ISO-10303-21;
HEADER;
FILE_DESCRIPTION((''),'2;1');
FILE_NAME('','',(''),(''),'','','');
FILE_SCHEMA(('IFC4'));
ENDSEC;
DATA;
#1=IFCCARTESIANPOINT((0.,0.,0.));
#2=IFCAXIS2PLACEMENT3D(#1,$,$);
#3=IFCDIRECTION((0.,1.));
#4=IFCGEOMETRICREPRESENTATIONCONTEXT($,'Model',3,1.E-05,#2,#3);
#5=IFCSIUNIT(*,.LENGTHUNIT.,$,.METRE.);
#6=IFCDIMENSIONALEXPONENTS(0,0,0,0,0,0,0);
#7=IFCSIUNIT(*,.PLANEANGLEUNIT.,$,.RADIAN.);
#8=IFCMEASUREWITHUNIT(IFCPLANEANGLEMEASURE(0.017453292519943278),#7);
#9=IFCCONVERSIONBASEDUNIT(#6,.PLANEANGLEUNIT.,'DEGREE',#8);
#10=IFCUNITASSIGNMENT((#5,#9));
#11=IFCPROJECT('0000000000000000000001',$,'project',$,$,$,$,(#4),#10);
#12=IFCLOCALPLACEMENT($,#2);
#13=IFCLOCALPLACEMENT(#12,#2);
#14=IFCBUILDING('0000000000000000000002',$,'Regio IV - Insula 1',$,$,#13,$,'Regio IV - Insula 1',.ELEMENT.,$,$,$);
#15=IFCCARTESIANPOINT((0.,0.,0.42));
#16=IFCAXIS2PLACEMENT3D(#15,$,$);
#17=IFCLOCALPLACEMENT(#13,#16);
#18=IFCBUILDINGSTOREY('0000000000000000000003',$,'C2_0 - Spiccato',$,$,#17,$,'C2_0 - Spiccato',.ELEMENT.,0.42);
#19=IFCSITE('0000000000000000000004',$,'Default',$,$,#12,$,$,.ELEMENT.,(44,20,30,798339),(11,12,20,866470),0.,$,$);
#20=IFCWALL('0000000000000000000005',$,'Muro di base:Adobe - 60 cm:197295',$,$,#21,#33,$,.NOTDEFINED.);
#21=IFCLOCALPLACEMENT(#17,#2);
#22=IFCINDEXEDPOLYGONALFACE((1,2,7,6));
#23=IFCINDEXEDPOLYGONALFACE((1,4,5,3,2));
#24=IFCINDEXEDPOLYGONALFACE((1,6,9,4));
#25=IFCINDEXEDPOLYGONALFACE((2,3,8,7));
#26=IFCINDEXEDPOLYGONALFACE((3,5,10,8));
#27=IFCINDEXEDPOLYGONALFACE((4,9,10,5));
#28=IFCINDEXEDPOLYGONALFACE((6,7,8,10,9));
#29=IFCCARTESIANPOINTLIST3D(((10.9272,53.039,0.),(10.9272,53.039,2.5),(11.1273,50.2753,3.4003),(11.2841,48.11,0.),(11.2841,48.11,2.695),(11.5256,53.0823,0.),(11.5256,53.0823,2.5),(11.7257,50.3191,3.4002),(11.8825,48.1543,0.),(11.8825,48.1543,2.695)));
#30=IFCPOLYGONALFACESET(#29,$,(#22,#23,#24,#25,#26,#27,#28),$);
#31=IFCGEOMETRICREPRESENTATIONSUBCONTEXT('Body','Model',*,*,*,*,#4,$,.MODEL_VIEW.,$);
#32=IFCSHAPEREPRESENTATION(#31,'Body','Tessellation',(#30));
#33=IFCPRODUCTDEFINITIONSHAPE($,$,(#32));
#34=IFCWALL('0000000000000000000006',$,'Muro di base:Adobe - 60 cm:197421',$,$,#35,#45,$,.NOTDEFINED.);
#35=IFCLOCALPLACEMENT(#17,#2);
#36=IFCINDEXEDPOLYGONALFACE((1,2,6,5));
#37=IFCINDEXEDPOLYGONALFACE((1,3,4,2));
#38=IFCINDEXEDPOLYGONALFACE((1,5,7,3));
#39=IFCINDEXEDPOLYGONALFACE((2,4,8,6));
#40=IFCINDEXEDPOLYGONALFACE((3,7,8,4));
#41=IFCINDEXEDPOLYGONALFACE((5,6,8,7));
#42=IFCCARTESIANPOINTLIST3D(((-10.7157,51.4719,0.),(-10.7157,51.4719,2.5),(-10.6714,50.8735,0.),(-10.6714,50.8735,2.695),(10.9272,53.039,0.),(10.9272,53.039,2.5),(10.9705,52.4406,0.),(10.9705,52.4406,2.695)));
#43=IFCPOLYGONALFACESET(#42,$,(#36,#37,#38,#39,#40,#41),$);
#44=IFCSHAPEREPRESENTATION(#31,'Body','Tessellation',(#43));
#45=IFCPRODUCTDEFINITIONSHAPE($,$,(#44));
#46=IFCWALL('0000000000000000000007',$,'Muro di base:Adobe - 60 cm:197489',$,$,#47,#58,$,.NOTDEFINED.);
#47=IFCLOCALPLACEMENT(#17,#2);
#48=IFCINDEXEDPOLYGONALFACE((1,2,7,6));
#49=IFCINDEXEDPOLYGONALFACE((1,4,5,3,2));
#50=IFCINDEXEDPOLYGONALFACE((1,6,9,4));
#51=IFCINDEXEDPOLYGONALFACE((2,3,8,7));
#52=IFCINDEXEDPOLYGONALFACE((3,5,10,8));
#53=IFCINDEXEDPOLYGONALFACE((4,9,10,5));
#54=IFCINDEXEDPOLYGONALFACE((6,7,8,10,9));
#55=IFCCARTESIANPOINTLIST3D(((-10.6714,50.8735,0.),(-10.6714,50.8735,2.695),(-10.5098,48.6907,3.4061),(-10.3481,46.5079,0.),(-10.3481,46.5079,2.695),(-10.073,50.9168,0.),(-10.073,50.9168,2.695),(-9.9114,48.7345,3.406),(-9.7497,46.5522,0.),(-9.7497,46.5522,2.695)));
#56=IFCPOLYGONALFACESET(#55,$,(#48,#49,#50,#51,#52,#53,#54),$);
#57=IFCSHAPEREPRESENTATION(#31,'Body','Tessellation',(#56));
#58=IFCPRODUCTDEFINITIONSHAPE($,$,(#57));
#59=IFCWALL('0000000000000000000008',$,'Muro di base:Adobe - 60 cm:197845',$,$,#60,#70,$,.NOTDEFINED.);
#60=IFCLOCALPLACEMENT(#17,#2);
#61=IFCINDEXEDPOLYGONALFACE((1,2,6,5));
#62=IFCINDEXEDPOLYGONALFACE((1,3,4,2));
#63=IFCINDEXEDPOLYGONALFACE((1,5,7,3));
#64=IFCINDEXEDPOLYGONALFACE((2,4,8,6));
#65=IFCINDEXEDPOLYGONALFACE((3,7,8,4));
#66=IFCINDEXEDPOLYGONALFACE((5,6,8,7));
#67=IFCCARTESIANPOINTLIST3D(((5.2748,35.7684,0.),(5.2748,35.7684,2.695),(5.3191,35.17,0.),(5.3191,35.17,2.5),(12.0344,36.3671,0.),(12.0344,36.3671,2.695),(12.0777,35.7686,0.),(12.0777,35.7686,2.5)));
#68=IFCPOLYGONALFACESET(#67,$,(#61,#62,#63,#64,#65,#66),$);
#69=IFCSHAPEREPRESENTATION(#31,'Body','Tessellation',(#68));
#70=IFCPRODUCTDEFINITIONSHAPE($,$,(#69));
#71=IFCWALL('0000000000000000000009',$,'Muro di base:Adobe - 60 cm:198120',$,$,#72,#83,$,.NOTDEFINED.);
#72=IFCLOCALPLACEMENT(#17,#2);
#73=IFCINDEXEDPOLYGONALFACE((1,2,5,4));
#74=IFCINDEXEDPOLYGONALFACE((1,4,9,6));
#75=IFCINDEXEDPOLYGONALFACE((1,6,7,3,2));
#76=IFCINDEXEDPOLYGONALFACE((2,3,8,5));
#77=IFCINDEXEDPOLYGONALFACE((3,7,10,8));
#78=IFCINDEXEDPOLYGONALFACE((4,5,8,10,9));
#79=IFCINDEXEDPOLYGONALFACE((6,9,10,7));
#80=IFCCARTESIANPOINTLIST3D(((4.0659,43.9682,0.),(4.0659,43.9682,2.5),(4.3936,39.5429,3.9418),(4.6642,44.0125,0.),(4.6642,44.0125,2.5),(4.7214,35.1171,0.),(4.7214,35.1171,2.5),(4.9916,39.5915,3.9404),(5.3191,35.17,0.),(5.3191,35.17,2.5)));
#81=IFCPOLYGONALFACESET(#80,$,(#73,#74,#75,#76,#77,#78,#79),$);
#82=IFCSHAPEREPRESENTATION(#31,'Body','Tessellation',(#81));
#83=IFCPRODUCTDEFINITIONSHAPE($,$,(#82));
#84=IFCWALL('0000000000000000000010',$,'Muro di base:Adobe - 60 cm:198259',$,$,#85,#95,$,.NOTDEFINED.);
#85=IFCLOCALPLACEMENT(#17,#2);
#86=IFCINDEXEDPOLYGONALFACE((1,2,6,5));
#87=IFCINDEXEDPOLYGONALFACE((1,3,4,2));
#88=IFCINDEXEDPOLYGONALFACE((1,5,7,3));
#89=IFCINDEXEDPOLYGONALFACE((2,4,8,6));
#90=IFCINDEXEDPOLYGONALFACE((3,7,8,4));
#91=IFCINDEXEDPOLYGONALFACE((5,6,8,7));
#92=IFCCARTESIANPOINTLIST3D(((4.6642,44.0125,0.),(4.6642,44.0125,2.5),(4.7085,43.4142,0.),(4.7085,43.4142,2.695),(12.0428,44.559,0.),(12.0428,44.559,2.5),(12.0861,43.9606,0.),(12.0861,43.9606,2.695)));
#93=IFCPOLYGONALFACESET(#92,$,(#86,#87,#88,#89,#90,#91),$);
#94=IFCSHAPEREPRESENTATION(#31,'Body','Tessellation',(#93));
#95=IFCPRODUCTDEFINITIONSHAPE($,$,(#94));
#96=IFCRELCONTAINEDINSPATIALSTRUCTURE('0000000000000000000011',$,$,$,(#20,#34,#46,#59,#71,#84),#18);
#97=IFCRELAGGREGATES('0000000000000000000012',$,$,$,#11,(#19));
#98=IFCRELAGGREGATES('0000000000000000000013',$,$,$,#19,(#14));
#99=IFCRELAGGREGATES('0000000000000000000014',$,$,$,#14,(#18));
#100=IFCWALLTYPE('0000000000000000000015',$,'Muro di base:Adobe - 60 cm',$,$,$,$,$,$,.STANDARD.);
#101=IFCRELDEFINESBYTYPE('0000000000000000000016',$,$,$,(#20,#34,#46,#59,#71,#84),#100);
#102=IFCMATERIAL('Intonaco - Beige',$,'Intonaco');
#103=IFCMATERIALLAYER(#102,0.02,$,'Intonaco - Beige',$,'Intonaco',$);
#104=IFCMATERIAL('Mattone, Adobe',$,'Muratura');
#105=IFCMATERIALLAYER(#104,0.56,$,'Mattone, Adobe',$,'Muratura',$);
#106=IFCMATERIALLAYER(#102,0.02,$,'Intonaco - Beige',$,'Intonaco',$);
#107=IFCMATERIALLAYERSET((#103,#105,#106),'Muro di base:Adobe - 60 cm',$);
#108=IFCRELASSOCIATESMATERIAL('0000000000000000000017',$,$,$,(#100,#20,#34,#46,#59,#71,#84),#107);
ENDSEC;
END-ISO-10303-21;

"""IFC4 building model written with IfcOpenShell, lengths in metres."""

from ifc_helpers import new_model, entity, si_unit, converted_unit, direction, frame, origin, place, context, subcontext, project, spatial, polyline, outline, extrude, clip, bounded_halfspace, material, layer, layer_set, layer_usage, type_object, element, save


model = new_model("IFC4")

# Units and contexts
model_context = context("Model", 3, precision=1e-05, world=origin(), true_north=direction((0.0, 1.0)))
body_context = subcontext(model_context, "Body", "Model", "MODEL_VIEW")
ifc_project = project(units=[si_unit("LENGTHUNIT", "METRE"), converted_unit("PLANEANGLEUNIT", "DEGREE", entity("IfcPlaneAngleMeasure", 0.017453292519943278), si_unit("PLANEANGLEUNIT", "RADIAN"), dimensions=[0, 0, 0, 0, 0, 0, 0])], contexts=[model_context])

# Site, building, storey
site_placement = place(None, origin())
site = spatial("IfcSite", under=ifc_project, at=site_placement, Name="Default", CompositionType="ELEMENT", RefLatitude=(44, 20, 30, 798339), RefLongitude=(11, 12, 20, 866470), RefElevation=0.0)
building_placement = place(site_placement, origin())
building = spatial("IfcBuilding", under=site, at=building_placement, Name="Regio IV - Insula 1", LongName="Regio IV - Insula 1", CompositionType="ELEMENT")
storey_placement = place(building_placement, frame((0.0, 0.0, 0.42)))
storey = spatial("IfcBuildingStorey", under=building, at=storey_placement, Name="C2_0 - Spiccato", LongName="C2_0 - Spiccato", CompositionType="ELEMENT", Elevation=0.42)

# Shared definitions
ifc_material_1 = material(Name="Intonaco - Beige", Category="Intonaco")
ifc_layer_1 = layer(ifc_material_1, 0.02, Name="Intonaco - Beige", Category="Intonaco")
ifc_material_2 = material(Name="Mattone, Adobe", Category="Muratura")
ifc_layer_2 = layer(ifc_material_2, 0.56, Name="Mattone, Adobe", Category="Muratura")
ifc_layer_3 = layer(ifc_material_1, 0.02, Name="Intonaco - Beige", Category="Intonaco")
ifc_layer_set = layer_set([ifc_layer_1, ifc_layer_2, ifc_layer_3], Name="Muro di base:Adobe - 60 cm")
wall_type = type_object("IfcWallType", Name="Muro di base:Adobe - 60 cm", PredefinedType="STANDARD", material=ifc_layer_set)

# Walls
ifc_layer_usage_1 = layer_usage(ifc_layer_set, "AXIS2", "NEGATIVE", 0.3)
wall_1_placement = place(storey_placement, frame((11.5833, 48.1316, 0.0), z_axis=(0.0, 0.0, 1.0), x_axis=(-0.07222, 0.997389, 0.0)))
element("IfcWall", 1, at=wall_1_placement, inside=storey, type_object=wall_type, material=ifc_layer_usage_1, Name="Muro di base:Adobe - 60 cm:197295", PredefinedType="NOTDEFINED", context=body_context, shape_type="Clipping", body=[
    clip(clip(extrude(outline(polyline([(4.942, -0.3), (4.942, 0.3), (4.342, 0.3), (0.0, 0.3), (0.001, -0.3), (4.942, -0.3)])), origin(), (0.0, 0.0, 1.0), 3.4003), bounded_halfspace(frame((2.1715, -0.3, 3.4002), z_axis=(0.309017, 0.0, 0.951057), x_axis=(0.0, 1.0, 0.0)), False, frame((2.1715, -0.3, 3.4002)), polyline([(0.0, 0.0), (2.7705, 0.0), (2.7705, 0.6), (2.1705, 0.6), (-0.0005, 0.6), (0.0, 0.0)]))), bounded_halfspace(frame((0.001, -0.3, 2.695), z_axis=(-0.309017, -0.000507, 0.951057), x_axis=(0.001641, -0.999999, 0.0)), False, frame((0.001, -0.3, 2.695)), polyline([(0.0, 0.0), (2.1705, 0.0), (2.17, 0.6), (-0.001, 0.6), (0.0, 0.0)]))),
])
ifc_layer_usage_2 = layer_usage(ifc_layer_set, "AXIS2", "NEGATIVE", 0.3)
wall_2_placement = place(storey_placement, frame((10.9489, 52.7398, 0.0), z_axis=(0.0, 0.0, 1.0), x_axis=(-0.997389, -0.07222, 0.0)))
element("IfcWall", 2, at=wall_2_placement, inside=storey, type_object=wall_type, material=ifc_layer_usage_2, Name="Muro di base:Adobe - 60 cm:197421", PredefinedType="NOTDEFINED", context=body_context, shape_type="Clipping", body=[
    clip(extrude(outline(polyline([(21.6996, -0.3), (21.6986, 0.3), (21.0986, 0.3), (0.0, 0.3), (0.0, -0.3), (21.6996, -0.3)])), origin(), (0.0, 0.0, 1.0), 2.695), bounded_halfspace(frame((0.0, -0.3, 2.5), z_axis=(0.0, -0.309017, 0.951057), x_axis=(1.0, 0.0, 0.0)), False, frame((0.0, -0.3, 2.5)), polyline([(0.0, 0.0), (21.6996, 0.0), (21.6986, 0.6), (21.0986, 0.6), (0.0, 0.6), (0.0, 0.0)]))),
])
ifc_layer_usage_3 = layer_usage(ifc_layer_set, "AXIS2", "NEGATIVE", 0.3)
wall_3_placement = place(storey_placement, frame((-10.3722, 50.8957, 0.0), z_axis=(0.0, 0.0, 1.0), x_axis=(0.073857, -0.997269, 0.0)))
element("IfcWall", 3, at=wall_3_placement, inside=storey, type_object=wall_type, material=ifc_layer_usage_3, Name="Muro di base:Adobe - 60 cm:197489", PredefinedType="NOTDEFINED", context=body_context, shape_type="Clipping", body=[
    clip(clip(extrude(outline(polyline([(4.3776, -0.3), (4.3776, 0.3), (0.001, 0.3), (0.0, -0.3), (4.3776, -0.3)])), origin(), (0.0, 0.0, 1.0), 3.4061), bounded_halfspace(frame((0.0, -0.3, 2.695), z_axis=(-0.309017, 0.000507, 0.951057), x_axis=(-0.001641, -0.999999, 0.0)), False, frame((0.0, -0.3, 2.695)), polyline([(0.0, 0.0), (2.1888, 0.0), (2.1893, 0.6), (0.001, 0.6), (0.0, 0.0)]))), bounded_halfspace(frame((2.1888, -0.3, 3.4061), z_axis=(0.309017, 0.0, 0.951057), x_axis=(0.0, 1.0, 0.0)), False, frame((2.1888, -0.3, 3.4061)), polyline([(0.0, 0.0), (2.1888, 0.0), (2.1888, 0.6), (0.0005, 0.6), (0.0, 0.0)]))),
])
ifc_layer_usage_4 = layer_usage(ifc_layer_set, "AXIS2", "NEGATIVE", 0.3)
wall_4_placement = place(storey_placement, frame((5.2926, 35.4688, 0.0), z_axis=(0.0, 0.0, 1.0), x_axis=(0.996101, 0.088225, 0.0)))
element("IfcWall", 4, at=wall_4_placement, inside=storey, type_object=wall_type, material=ifc_layer_usage_4, Name="Muro di base:Adobe - 60 cm:197845", PredefinedType="NOTDEFINED", context=body_context, shape_type="Clipping", body=[
    clip(extrude(outline(polyline([(6.7851, -0.3), (6.7947, 0.3), (0.0086, 0.3), (0.0, -0.3), (6.7851, -0.3)])), origin(), (0.0, 0.0, 1.0), 2.695), bounded_halfspace(frame((0.0, -0.3, 2.5), z_axis=(0.0, -0.309017, 0.951057), x_axis=(1.0, 0.0, 0.0)), False, frame((0.0, -0.3, 2.5)), polyline([(0.0, 0.0), (6.7851, 0.0), (6.7947, 0.6), (0.0086, 0.6), (0.0, 0.0)]))),
])
ifc_layer_usage_5 = layer_usage(ifc_layer_set, "AXIS2", "NEGATIVE", 0.3)
wall_5_placement = place(storey_placement, frame((5.0205, 35.1392, 0.0), z_axis=(0.0, 0.0, 1.0), x_axis=(-0.073857, 0.997269, 0.0)))
element("IfcWall", 5, at=wall_5_placement, inside=storey, type_object=wall_type, material=ifc_layer_usage_5, Name="Muro di base:Adobe - 60 cm:198120", PredefinedType="NOTDEFINED", context=body_context, shape_type="Clipping", body=[
    clip(clip(extrude(outline(polyline([(8.8754, -0.3), (8.8754, 0.3), (0.0, 0.3), (0.0086, -0.3), (0.6087, -0.3), (8.2754, -0.3), (8.8754, -0.3)])), origin(), (0.0, 0.0, 1.0), 3.9418), bounded_halfspace(frame((4.4423, -0.3, 3.9404), z_axis=(0.309017, 0.0, 0.951057), x_axis=(0.0, 1.0, 0.0)), False, frame((4.4423, -0.3, 3.9404)), polyline([(0.0, 0.0), (3.8331, 0.0), (4.4331, 0.0), (4.4331, 0.6), (-0.0043, 0.6), (0.0, 0.0)]))), bounded_halfspace(frame((0.0086, -0.3, 2.5), z_axis=(-0.308985, -0.004455, 0.951057), x_axis=(0.014415, -0.999896, 0.0)), False, frame((0.0086, -0.3, 2.5)), polyline([(0.0, 0.0), (0.6001, 0.0), (4.4336, 0.0), (4.4293, 0.6), (-0.0086, 0.6), (0.0, 0.0)]))),
])
ifc_layer_usage_6 = layer_usage(ifc_layer_set, "AXIS2", "NEGATIVE", 0.3)
wall_6_placement = place(storey_placement, frame((4.6864, 43.7134, 0.0), z_axis=(0.0, 0.0, 1.0), x_axis=(0.997269, 0.073857, 0.0)))
element("IfcWall", 6, at=wall_6_placement, inside=storey, type_object=wall_type, material=ifc_layer_usage_6, Name="Muro di base:Adobe - 60 cm:198259", PredefinedType="NOTDEFINED", context=body_context, shape_type="Clipping", body=[
    clip(extrude(outline(polyline([(7.3978, -0.3), (7.3988, 0.3), (0.0, 0.3), (0.0, -0.3), (6.7978, -0.3), (7.3978, -0.3)])), origin(), (0.0, 0.0, 1.0), 2.695), bounded_halfspace(frame((0.0, -0.3, 2.695), z_axis=(0.0, 0.309017, 0.951057), x_axis=(-1.0, 0.0, 0.0)), False, frame((0.0, -0.3, 2.695)), polyline([(0.0, 0.0), (6.7978, 0.0), (7.3978, 0.0), (7.3988, 0.6), (0.0, 0.6), (0.0, 0.0)]))),
])

save(model, "model.ifc")
